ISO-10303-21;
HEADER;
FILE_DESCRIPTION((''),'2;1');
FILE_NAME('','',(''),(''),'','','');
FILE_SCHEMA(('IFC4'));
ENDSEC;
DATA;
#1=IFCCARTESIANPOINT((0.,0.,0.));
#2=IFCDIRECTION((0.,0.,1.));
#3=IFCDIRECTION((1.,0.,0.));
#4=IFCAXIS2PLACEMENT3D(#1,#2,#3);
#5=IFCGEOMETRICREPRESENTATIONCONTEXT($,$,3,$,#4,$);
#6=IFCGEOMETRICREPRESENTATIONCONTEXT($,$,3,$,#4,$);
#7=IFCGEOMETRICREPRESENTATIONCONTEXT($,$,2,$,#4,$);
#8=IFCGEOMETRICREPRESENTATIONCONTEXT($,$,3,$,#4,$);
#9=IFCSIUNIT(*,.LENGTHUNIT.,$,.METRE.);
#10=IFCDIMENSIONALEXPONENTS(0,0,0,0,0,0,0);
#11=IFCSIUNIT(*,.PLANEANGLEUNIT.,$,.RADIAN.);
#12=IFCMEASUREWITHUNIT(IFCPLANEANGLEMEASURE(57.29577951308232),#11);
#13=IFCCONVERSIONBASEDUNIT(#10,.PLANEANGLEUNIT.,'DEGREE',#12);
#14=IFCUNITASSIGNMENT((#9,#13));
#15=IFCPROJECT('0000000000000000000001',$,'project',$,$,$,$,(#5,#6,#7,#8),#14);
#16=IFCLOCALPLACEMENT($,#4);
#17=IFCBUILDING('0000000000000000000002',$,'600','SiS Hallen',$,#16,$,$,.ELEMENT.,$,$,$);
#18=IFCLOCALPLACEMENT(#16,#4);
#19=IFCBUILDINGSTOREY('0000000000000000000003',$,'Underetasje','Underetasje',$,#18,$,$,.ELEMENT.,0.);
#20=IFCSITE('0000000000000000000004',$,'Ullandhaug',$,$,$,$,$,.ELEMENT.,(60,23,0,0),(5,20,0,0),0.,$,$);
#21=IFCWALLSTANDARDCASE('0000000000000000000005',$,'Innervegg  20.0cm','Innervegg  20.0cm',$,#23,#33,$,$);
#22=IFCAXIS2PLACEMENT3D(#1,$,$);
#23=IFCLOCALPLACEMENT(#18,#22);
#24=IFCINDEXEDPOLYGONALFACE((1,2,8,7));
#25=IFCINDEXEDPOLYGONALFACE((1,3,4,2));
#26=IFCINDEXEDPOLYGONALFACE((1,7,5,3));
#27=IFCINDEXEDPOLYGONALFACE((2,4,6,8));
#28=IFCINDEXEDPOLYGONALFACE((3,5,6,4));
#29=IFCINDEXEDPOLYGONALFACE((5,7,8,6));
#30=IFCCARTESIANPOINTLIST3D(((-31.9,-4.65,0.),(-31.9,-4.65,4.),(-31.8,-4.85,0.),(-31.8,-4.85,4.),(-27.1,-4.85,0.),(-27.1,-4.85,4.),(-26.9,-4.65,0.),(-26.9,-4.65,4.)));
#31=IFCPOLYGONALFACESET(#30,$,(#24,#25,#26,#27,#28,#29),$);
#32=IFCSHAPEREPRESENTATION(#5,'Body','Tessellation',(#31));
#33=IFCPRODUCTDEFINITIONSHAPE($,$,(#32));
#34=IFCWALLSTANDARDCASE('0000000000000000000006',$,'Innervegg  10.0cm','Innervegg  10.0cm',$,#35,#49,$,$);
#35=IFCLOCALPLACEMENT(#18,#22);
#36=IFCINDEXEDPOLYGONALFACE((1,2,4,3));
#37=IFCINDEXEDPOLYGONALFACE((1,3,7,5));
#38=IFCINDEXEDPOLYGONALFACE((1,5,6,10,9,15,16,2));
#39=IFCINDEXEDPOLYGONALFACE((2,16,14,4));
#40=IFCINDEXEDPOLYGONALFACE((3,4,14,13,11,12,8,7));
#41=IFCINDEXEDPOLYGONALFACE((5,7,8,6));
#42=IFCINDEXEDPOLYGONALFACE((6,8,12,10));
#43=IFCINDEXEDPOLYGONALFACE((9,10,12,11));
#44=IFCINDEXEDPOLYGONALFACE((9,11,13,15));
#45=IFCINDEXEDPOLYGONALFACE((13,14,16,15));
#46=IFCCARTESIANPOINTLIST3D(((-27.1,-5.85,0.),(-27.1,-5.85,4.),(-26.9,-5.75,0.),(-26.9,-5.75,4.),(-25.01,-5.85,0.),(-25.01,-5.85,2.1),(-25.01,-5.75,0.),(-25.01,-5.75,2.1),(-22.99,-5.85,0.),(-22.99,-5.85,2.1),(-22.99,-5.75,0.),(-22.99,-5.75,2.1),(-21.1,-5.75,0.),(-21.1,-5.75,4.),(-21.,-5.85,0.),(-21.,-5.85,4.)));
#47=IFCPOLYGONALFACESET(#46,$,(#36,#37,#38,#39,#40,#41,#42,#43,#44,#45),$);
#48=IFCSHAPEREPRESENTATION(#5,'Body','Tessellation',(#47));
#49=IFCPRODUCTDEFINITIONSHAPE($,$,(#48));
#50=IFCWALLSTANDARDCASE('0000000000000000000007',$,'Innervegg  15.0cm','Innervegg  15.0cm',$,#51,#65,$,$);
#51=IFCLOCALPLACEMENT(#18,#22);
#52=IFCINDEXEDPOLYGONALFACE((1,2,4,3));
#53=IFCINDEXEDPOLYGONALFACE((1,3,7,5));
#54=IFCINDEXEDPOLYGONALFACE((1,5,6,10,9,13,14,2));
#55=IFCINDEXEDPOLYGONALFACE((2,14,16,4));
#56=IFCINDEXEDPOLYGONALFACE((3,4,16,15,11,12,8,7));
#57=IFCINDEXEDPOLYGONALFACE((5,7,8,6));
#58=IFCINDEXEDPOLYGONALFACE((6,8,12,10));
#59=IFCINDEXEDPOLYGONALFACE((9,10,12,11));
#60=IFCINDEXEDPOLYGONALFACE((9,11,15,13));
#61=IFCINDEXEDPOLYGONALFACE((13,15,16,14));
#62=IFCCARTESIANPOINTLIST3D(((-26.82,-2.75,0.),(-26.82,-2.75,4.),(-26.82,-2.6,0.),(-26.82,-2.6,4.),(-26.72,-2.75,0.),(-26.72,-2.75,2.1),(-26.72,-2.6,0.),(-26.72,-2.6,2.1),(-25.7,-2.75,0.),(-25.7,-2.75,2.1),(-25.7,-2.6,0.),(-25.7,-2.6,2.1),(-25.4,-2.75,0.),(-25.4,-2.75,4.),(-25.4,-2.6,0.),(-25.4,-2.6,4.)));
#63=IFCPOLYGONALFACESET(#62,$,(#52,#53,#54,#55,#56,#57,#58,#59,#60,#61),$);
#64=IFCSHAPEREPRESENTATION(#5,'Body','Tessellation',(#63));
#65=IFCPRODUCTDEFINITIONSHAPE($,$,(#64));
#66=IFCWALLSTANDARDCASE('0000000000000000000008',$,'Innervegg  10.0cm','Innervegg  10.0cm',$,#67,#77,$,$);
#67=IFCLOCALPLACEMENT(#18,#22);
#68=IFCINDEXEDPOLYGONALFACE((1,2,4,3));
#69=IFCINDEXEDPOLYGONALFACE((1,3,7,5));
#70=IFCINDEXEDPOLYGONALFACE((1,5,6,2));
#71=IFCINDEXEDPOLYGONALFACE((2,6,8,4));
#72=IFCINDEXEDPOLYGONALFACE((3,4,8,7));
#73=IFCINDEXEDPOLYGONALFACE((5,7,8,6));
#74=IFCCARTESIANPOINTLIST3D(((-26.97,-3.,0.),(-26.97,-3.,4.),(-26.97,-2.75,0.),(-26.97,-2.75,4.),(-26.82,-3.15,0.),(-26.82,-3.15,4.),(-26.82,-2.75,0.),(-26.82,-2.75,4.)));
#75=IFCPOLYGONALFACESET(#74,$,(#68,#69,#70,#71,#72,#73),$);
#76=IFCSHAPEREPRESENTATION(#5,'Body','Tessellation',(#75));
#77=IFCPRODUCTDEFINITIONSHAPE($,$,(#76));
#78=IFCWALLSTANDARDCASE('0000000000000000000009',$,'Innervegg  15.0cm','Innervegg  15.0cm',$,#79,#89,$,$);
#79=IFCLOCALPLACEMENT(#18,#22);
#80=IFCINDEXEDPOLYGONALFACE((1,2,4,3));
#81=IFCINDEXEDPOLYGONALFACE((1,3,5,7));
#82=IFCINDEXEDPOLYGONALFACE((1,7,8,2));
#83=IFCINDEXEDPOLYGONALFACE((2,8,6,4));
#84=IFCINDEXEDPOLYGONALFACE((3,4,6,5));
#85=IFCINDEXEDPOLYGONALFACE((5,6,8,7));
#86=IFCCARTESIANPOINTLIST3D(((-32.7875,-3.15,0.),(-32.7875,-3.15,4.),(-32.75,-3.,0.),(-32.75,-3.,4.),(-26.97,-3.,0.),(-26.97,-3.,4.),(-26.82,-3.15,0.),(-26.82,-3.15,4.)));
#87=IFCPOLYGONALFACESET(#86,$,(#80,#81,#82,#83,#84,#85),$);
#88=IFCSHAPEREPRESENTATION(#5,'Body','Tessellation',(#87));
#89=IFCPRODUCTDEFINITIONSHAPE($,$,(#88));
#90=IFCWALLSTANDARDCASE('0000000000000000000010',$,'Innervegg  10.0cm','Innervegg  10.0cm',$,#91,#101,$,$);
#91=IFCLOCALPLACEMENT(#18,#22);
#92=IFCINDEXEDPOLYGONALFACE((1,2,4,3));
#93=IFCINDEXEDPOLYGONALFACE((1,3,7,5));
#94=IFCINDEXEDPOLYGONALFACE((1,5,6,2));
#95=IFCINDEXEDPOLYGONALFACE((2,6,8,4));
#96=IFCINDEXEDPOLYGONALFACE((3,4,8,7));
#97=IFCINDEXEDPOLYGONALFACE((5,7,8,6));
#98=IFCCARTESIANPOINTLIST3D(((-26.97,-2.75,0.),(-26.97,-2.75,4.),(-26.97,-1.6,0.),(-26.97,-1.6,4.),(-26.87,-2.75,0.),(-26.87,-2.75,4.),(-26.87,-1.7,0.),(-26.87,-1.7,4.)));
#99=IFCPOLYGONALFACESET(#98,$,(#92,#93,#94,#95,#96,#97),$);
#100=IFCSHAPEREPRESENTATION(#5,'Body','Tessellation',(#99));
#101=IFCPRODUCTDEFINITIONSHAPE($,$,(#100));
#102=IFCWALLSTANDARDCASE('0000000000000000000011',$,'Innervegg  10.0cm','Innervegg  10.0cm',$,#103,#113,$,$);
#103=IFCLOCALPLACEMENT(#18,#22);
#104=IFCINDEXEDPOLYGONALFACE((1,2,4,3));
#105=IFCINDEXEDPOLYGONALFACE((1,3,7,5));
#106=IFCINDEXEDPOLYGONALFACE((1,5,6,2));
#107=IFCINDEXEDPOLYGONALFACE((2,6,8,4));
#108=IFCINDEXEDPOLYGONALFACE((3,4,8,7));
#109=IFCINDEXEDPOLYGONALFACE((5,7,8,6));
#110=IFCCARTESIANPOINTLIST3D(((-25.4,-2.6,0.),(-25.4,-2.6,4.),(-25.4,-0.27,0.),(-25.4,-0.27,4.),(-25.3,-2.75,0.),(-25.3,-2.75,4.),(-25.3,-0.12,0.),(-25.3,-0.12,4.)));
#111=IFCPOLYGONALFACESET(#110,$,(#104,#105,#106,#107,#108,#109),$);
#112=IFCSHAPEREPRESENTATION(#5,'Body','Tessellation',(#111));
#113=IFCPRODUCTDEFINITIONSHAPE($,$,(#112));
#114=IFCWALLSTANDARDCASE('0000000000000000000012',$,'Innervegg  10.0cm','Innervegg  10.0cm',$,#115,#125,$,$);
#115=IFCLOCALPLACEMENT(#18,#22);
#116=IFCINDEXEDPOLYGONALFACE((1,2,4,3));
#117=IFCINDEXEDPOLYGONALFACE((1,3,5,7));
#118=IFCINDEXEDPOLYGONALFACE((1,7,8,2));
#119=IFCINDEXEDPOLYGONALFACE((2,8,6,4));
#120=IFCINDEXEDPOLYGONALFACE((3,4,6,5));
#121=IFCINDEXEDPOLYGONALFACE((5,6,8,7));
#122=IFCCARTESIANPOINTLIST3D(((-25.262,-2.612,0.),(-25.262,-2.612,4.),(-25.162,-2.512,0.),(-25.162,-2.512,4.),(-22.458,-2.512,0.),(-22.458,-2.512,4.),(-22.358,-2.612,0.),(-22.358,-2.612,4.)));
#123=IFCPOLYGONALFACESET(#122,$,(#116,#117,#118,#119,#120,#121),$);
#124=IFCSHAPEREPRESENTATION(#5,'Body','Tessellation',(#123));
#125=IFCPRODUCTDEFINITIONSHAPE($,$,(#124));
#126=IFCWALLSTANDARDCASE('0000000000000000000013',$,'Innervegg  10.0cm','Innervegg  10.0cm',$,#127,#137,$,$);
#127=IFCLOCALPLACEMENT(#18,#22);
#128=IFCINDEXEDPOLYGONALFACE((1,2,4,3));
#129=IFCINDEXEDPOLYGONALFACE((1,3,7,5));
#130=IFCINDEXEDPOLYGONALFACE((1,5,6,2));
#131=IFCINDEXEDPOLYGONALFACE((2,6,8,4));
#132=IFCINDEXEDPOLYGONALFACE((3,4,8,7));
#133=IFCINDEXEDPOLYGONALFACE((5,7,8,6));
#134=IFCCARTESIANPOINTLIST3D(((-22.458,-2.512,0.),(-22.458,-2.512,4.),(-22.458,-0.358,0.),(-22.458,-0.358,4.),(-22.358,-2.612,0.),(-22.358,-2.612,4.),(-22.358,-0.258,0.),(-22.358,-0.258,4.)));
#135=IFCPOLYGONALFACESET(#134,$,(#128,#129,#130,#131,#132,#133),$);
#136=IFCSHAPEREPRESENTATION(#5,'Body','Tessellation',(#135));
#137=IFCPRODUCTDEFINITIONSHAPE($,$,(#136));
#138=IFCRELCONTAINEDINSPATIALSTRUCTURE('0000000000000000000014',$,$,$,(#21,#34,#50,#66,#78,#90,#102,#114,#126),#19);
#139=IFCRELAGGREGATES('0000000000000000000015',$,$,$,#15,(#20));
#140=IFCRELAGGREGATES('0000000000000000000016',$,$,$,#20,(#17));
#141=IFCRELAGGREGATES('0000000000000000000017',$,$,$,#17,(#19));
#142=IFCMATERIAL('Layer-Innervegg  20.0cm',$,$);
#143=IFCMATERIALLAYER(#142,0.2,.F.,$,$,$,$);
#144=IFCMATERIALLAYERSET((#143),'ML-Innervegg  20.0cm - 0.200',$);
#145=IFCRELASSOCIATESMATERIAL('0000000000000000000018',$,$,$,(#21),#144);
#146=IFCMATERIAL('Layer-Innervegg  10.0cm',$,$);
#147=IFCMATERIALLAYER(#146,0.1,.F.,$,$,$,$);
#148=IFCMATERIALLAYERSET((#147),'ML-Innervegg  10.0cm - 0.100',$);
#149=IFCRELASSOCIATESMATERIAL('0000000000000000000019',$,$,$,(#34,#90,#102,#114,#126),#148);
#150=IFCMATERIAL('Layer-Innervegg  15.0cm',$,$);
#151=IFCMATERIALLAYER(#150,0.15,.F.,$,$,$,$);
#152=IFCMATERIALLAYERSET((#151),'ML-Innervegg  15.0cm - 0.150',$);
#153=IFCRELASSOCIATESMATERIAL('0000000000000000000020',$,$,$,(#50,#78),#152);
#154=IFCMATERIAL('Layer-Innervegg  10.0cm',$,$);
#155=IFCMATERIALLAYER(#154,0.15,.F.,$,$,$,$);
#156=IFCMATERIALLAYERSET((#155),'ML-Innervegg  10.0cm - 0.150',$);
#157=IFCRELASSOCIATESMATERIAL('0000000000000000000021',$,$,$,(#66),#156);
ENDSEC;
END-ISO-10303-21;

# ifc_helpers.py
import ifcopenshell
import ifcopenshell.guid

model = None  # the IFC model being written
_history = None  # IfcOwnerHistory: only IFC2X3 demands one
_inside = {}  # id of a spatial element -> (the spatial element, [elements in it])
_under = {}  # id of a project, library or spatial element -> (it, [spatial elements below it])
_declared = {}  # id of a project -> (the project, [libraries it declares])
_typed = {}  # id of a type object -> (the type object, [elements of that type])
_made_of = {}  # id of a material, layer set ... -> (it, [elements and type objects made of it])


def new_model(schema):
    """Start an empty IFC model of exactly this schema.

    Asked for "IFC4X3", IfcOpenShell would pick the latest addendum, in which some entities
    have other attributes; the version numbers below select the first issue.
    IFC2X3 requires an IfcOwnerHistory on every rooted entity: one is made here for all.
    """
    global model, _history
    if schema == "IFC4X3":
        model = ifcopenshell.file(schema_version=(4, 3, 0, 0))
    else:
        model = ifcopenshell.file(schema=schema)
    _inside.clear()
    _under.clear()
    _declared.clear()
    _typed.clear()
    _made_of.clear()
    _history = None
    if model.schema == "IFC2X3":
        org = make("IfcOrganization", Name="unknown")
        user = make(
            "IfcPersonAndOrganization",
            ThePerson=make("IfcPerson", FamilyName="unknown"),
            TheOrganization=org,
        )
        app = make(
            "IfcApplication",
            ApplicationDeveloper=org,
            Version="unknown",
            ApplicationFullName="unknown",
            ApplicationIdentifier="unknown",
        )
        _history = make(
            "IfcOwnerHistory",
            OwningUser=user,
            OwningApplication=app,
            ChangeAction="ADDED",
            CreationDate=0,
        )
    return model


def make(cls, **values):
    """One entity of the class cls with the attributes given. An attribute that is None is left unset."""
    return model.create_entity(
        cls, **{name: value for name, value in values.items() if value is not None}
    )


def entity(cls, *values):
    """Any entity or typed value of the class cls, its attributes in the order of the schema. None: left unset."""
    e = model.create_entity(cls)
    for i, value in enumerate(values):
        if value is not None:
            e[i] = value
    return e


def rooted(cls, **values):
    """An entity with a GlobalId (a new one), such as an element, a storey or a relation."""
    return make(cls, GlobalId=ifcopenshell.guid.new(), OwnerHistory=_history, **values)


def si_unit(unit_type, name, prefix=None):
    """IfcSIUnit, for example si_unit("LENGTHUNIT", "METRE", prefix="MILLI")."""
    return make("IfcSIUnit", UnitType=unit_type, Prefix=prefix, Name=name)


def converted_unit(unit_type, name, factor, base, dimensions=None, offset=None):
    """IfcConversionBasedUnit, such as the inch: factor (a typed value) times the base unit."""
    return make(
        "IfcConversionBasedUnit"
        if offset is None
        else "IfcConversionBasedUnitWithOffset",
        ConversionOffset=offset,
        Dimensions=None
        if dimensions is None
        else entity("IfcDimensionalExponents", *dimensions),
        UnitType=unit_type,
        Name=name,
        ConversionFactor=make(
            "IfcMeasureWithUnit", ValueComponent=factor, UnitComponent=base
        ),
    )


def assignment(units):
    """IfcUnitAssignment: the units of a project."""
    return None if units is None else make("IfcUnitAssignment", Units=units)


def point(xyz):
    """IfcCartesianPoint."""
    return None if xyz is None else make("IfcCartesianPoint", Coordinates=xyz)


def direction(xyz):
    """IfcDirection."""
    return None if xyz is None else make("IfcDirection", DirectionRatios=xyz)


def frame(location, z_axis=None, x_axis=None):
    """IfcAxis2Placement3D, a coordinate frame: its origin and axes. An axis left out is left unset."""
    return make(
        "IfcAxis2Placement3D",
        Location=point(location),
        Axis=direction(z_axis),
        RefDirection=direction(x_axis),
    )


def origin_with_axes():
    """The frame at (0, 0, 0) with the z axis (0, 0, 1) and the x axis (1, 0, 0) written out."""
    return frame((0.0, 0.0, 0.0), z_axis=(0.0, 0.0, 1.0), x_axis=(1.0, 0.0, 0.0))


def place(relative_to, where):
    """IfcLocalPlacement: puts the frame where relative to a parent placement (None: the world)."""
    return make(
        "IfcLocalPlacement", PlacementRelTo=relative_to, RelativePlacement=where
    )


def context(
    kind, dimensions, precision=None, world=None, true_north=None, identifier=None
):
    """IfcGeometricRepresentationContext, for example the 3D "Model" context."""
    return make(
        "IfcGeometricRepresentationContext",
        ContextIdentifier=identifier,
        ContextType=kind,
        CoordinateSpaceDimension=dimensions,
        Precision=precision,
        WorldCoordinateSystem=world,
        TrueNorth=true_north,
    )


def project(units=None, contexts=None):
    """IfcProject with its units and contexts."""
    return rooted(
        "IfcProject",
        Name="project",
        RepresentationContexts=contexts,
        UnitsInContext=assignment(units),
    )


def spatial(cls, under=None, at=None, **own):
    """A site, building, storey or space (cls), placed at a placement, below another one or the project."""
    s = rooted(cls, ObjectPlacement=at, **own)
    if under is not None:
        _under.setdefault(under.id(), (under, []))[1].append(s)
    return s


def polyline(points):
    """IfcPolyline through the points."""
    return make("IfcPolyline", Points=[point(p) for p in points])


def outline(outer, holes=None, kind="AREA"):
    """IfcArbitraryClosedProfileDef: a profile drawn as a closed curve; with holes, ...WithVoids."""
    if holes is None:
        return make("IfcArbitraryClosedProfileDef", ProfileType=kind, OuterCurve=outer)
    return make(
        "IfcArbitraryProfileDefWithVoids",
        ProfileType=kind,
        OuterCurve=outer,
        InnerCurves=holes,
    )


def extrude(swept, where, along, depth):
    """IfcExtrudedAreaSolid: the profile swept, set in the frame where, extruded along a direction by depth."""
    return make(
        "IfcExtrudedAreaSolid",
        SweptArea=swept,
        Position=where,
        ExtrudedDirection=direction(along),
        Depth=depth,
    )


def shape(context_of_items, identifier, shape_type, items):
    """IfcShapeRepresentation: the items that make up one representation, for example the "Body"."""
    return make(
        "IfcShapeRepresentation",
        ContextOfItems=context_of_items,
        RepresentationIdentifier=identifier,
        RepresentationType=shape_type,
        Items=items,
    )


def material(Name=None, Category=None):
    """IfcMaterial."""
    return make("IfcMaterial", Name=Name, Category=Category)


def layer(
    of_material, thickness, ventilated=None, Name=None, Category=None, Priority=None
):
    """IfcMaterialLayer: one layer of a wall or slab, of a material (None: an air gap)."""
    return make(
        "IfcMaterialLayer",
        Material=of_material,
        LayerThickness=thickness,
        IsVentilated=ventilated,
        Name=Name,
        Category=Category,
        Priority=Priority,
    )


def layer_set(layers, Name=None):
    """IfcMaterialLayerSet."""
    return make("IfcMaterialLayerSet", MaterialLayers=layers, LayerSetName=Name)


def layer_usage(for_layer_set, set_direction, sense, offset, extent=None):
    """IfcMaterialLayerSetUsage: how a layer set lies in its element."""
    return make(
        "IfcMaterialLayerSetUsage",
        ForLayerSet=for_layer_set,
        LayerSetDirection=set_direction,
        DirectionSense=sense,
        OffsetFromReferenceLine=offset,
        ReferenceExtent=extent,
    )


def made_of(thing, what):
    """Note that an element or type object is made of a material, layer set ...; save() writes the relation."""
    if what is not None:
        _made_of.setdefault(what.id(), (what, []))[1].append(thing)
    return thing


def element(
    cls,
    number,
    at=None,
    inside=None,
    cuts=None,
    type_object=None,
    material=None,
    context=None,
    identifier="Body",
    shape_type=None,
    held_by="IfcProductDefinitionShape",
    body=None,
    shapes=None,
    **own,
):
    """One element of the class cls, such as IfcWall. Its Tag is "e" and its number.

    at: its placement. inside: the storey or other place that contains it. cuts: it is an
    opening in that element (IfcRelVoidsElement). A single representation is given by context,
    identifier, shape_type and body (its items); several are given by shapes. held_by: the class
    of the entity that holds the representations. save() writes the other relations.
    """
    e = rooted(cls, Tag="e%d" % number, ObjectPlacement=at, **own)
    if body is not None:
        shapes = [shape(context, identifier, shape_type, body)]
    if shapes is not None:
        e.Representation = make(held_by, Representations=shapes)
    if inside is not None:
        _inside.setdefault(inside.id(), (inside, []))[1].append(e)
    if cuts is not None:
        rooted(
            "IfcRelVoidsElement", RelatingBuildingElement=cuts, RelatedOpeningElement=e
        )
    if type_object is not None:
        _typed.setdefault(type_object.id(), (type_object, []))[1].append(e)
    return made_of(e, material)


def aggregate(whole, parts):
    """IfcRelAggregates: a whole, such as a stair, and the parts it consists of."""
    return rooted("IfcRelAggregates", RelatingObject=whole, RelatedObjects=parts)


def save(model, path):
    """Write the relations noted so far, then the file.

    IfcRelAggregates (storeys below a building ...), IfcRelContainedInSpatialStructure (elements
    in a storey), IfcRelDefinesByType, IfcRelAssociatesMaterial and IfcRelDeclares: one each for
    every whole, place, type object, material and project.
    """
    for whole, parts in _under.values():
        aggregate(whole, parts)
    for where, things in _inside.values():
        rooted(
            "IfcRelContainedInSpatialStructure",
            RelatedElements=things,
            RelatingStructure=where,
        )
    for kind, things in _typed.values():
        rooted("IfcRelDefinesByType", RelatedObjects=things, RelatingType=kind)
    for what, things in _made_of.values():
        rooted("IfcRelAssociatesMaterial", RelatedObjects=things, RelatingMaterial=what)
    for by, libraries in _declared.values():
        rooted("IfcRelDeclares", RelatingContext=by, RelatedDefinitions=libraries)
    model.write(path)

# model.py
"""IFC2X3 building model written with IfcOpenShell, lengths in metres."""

from ifc_helpers import new_model, entity, si_unit, converted_unit, frame, origin_with_axes, place, context, project, spatial, polyline, outline, extrude, material, layer, layer_set, layer_usage, element, save


model = new_model("IFC2X3")

# Units and contexts
context_of_model_1 = context(None, 3, world=origin_with_axes())
context_of_model_2 = context(None, 3, world=origin_with_axes())
context_of_model_3 = context(None, 2, world=origin_with_axes())
context_of_model_4 = context(None, 3, world=origin_with_axes())
ifc_project = project(units=[si_unit("LENGTHUNIT", "METRE"), converted_unit("PLANEANGLEUNIT", "DEGREE", entity("IfcPlaneAngleMeasure", 57.29577951308232), si_unit("PLANEANGLEUNIT", "RADIAN"), dimensions=[0, 0, 0, 0, 0, 0, 0])], contexts=[context_of_model_1, context_of_model_2, context_of_model_3, context_of_model_4])

# Site, building, storey
site = spatial("IfcSite", under=ifc_project, Name="Ullandhaug", CompositionType="ELEMENT", RefLatitude=(60, 23, 0, 0), RefLongitude=(5, 20, 0, 0), RefElevation=0.0)
building_placement = place(None, origin_with_axes())
building = spatial("IfcBuilding", under=site, at=building_placement, Name="600", Description="SiS Hallen", CompositionType="ELEMENT")
storey_placement = place(building_placement, origin_with_axes())
storey = spatial("IfcBuildingStorey", under=building, at=storey_placement, Name="Underetasje", Description="Underetasje", CompositionType="ELEMENT", Elevation=0.0)

# Shared definitions
ifc_material_1 = material(Name="Layer-Innervegg  10.0cm")
ifc_layer_1 = layer(ifc_material_1, 0.1, ventilated=False)
ifc_layer_set_1 = layer_set([ifc_layer_1], Name="ML-Innervegg  10.0cm - 0.100")
ifc_layer_usage_1 = layer_usage(ifc_layer_set_1, "AXIS2", "POSITIVE", 0.0)

# Shared definitions
ifc_material_2 = material(Name="Layer-Innervegg  20.0cm")
ifc_layer_2 = layer(ifc_material_2, 0.2, ventilated=False)
ifc_layer_set_2 = layer_set([ifc_layer_2], Name="ML-Innervegg  20.0cm - 0.200")
ifc_layer_usage_2 = layer_usage(ifc_layer_set_2, "AXIS2", "POSITIVE", 0.0)

# Wall
wall_1_placement = place(storey_placement, frame((-26.9, -4.65, 0.0), z_axis=(0.0, 0.0, 1.0), x_axis=(-1.0, 0.0, 0.0)))
element("IfcWallStandardCase", 1, at=wall_1_placement, inside=storey, material=ifc_layer_usage_2, Name="Innervegg  20.0cm", Description="Innervegg  20.0cm", context=context_of_model_1, shape_type="SweptSolid", body=[
    extrude(outline(polyline([(0.0, 0.0), (5.0, 0.0), (4.9, 0.2), (0.2, 0.2), (0.0, 0.0)])), frame((0.0, 0.0, 0.0), z_axis=(0.0, 0.0, 1.0), x_axis=(1.0, 0.0, 0.0)), (0.0, 0.0, 1.0), 4.0),
])

# Walls, openings
wall_2_placement = place(storey_placement, frame((-27.1, -5.85, 0.0), z_axis=(0.0, 0.0, 1.0), x_axis=(1.0, 0.0, 0.0)))
wall_2 = element("IfcWallStandardCase", 2, at=wall_2_placement, inside=storey, material=ifc_layer_usage_1, Name="Innervegg  10.0cm", Description="Innervegg  10.0cm", context=context_of_model_1, shape_type="SweptSolid", body=[
    extrude(outline(polyline([(0.0, 0.0), (6.1, 0.0), (6.0, 0.1), (0.2, 0.1), (0.0, 0.0)])), origin_with_axes(), (0.0, 0.0, 1.0), 4.0),
])
opening_1_placement = place(wall_2_placement, frame((2.09, 0.1, 0.0), z_axis=(0.0, 0.0, 1.0), x_axis=(1.0, 0.0, 0.0)))
element("IfcOpeningElement", 3, at=opening_1_placement, cuts=wall_2, context=context_of_model_1, shape_type="SweptSolid", body=[
    extrude(outline(polyline([(0.0, 0.0), (2.1, 0.0), (2.1, 2.02), (0.0, 2.02), (0.0, 0.0)])), frame((0.0, 0.0, 0.0), z_axis=(0.0, 1.0, 0.0), x_axis=(0.0, 0.0, 1.0)), (0.0, 0.0, -1.0), 0.1),
])
ifc_material_3 = material(Name="Layer-Innervegg  15.0cm")
ifc_layer_3 = layer(ifc_material_3, 0.15, ventilated=False)
ifc_layer_set_3 = layer_set([ifc_layer_3], Name="ML-Innervegg  15.0cm - 0.150")
ifc_layer_usage_3 = layer_usage(ifc_layer_set_3, "AXIS2", "POSITIVE", 0.0)
wall_3_placement = place(storey_placement, frame((-25.4, -2.6, 0.0), z_axis=(0.0, 0.0, 1.0), x_axis=(-1.0, 0.0, 0.0)))
wall_3 = element("IfcWallStandardCase", 4, at=wall_3_placement, inside=storey, material=ifc_layer_usage_3, Name="Innervegg  15.0cm", Description="Innervegg  15.0cm", context=context_of_model_1, shape_type="SweptSolid", body=[
    extrude(outline(polyline([(0.0, 0.0), (1.42, 0.0), (1.42, 0.15), (0.0, 0.15), (0.0, 0.0)])), frame((0.0, 0.0, 0.0), z_axis=(0.0, 0.0, 1.0), x_axis=(1.0, 0.0, 0.0)), (0.0, 0.0, 1.0), 4.0),
])
opening_2_placement = place(wall_3_placement, frame((0.3, 0.15, 0.0), z_axis=(0.0, 0.0, 1.0), x_axis=(1.0, 0.0, 0.0)))
element("IfcOpeningElement", 5, at=opening_2_placement, cuts=wall_3, context=context_of_model_1, shape_type="SweptSolid", body=[
    extrude(outline(polyline([(0.0, 0.0), (2.1, 0.0), (2.1, 1.02), (0.0, 1.02), (0.0, 0.0)])), frame((0.0, 0.0, 0.0), z_axis=(0.0, 1.0, 0.0), x_axis=(0.0, 0.0, 1.0)), (0.0, 0.0, -1.0), 0.15),
])

# Walls
ifc_material_4 = material(Name="Layer-Innervegg  10.0cm")
ifc_layer_4 = layer(ifc_material_4, 0.15, ventilated=False)
ifc_layer_set_4 = layer_set([ifc_layer_4], Name="ML-Innervegg  10.0cm - 0.150")
ifc_layer_usage_4 = layer_usage(ifc_layer_set_4, "AXIS2", "POSITIVE", 0.0)
wall_4_placement = place(storey_placement, frame((-26.97, -2.75, 0.0), z_axis=(0.0, 0.0, 1.0), x_axis=(0.0, -1.0, 0.0)))
element("IfcWallStandardCase", 6, at=wall_4_placement, inside=storey, material=ifc_layer_usage_4, Name="Innervegg  10.0cm", Description="Innervegg  10.0cm", context=context_of_model_1, shape_type="SweptSolid", body=[
    extrude(outline(polyline([(0.0, 0.0), (0.25, 0.0), (0.4, 0.15), (0.0, 0.15), (0.0, 0.0)])), frame((0.0, 0.0, 0.0), z_axis=(0.0, 0.0, 1.0), x_axis=(1.0, 0.0, 0.0)), (0.0, 0.0, 1.0), 4.0),
])
wall_5_placement = place(storey_placement, frame((-26.97, -3.0, 0.0), z_axis=(0.0, 0.0, 1.0), x_axis=(-1.0, 0.0, 0.0)))
element("IfcWallStandardCase", 7, at=wall_5_placement, inside=storey, material=ifc_layer_usage_3, Name="Innervegg  15.0cm", Description="Innervegg  15.0cm", context=context_of_model_1, shape_type="SweptSolid", body=[
    extrude(outline(polyline([(0.0, 0.0), (5.78, 0.0), (5.8175, 0.15), (-0.15, 0.15), (0.0, 0.0)])), frame((0.0, 0.0, 0.0), z_axis=(0.0, 0.0, 1.0), x_axis=(1.0, 0.0, 0.0)), (0.0, 0.0, 1.0), 4.0),
])
wall_6_placement = place(storey_placement, frame((-26.87, -2.75, 0.0), z_axis=(0.0, 0.0, 1.0), x_axis=(0.0, 1.0, 0.0)))
element("IfcWallStandardCase", 8, at=wall_6_placement, inside=storey, material=ifc_layer_usage_1, Name="Innervegg  10.0cm", Description="Innervegg  10.0cm", context=context_of_model_1, shape_type="SweptSolid", body=[
    extrude(outline(polyline([(0.0, 0.0), (1.05, 0.0), (1.15, 0.1), (0.0, 0.1), (0.0, 0.0)])), frame((0.0, 0.0, 0.0), z_axis=(0.0, 0.0, 1.0), x_axis=(1.0, 0.0, 0.0)), (0.0, 0.0, 1.0), 4.0),
])
wall_7_placement = place(storey_placement, frame((-25.3, -2.75, 0.0), z_axis=(0.0, 0.0, 1.0), x_axis=(0.0, 1.0, 0.0)))
element("IfcWallStandardCase", 9, at=wall_7_placement, inside=storey, material=ifc_layer_usage_1, Name="Innervegg  10.0cm", Description="Innervegg  10.0cm", context=context_of_model_1, shape_type="SweptSolid", body=[
    extrude(outline(polyline([(0.0, 0.0), (2.63, 0.0), (2.48, 0.1), (0.15, 0.1), (0.0, 0.0)])), frame((0.0, 0.0, 0.0), z_axis=(0.0, 0.0, 1.0), x_axis=(1.0, 0.0, 0.0)), (0.0, 0.0, 1.0), 4.0),
])
wall_8_placement = place(storey_placement, frame((-25.262, -2.612, 0.0), z_axis=(0.0, 0.0, 1.0), x_axis=(1.0, 0.0, 0.0)))
element("IfcWallStandardCase", 10, at=wall_8_placement, inside=storey, material=ifc_layer_usage_1, Name="Innervegg  10.0cm", Description="Innervegg  10.0cm", context=context_of_model_1, shape_type="SweptSolid", body=[
    extrude(outline(polyline([(0.0, 0.0), (2.904, 0.0), (2.804, 0.1), (0.1, 0.1), (0.0, 0.0)])), origin_with_axes(), (0.0, 0.0, 1.0), 4.0),
])
wall_9_placement = place(storey_placement, frame((-22.358, -2.612, 0.0), z_axis=(0.0, 0.0, 1.0), x_axis=(0.0, 1.0, 0.0)))
element("IfcWallStandardCase", 11, at=wall_9_placement, inside=storey, material=ifc_layer_usage_1, Name="Innervegg  10.0cm", Description="Innervegg  10.0cm", context=context_of_model_1, shape_type="SweptSolid", body=[
    extrude(outline(polyline([(0.0, 0.0), (2.354, 0.0), (2.254, 0.1), (0.1, 0.1), (0.0, 0.0)])), frame((0.0, 0.0, 0.0), z_axis=(0.0, 0.0, 1.0), x_axis=(1.0, 0.0, 0.0)), (0.0, 0.0, 1.0), 4.0),
])

save(model, "model.ifc")
